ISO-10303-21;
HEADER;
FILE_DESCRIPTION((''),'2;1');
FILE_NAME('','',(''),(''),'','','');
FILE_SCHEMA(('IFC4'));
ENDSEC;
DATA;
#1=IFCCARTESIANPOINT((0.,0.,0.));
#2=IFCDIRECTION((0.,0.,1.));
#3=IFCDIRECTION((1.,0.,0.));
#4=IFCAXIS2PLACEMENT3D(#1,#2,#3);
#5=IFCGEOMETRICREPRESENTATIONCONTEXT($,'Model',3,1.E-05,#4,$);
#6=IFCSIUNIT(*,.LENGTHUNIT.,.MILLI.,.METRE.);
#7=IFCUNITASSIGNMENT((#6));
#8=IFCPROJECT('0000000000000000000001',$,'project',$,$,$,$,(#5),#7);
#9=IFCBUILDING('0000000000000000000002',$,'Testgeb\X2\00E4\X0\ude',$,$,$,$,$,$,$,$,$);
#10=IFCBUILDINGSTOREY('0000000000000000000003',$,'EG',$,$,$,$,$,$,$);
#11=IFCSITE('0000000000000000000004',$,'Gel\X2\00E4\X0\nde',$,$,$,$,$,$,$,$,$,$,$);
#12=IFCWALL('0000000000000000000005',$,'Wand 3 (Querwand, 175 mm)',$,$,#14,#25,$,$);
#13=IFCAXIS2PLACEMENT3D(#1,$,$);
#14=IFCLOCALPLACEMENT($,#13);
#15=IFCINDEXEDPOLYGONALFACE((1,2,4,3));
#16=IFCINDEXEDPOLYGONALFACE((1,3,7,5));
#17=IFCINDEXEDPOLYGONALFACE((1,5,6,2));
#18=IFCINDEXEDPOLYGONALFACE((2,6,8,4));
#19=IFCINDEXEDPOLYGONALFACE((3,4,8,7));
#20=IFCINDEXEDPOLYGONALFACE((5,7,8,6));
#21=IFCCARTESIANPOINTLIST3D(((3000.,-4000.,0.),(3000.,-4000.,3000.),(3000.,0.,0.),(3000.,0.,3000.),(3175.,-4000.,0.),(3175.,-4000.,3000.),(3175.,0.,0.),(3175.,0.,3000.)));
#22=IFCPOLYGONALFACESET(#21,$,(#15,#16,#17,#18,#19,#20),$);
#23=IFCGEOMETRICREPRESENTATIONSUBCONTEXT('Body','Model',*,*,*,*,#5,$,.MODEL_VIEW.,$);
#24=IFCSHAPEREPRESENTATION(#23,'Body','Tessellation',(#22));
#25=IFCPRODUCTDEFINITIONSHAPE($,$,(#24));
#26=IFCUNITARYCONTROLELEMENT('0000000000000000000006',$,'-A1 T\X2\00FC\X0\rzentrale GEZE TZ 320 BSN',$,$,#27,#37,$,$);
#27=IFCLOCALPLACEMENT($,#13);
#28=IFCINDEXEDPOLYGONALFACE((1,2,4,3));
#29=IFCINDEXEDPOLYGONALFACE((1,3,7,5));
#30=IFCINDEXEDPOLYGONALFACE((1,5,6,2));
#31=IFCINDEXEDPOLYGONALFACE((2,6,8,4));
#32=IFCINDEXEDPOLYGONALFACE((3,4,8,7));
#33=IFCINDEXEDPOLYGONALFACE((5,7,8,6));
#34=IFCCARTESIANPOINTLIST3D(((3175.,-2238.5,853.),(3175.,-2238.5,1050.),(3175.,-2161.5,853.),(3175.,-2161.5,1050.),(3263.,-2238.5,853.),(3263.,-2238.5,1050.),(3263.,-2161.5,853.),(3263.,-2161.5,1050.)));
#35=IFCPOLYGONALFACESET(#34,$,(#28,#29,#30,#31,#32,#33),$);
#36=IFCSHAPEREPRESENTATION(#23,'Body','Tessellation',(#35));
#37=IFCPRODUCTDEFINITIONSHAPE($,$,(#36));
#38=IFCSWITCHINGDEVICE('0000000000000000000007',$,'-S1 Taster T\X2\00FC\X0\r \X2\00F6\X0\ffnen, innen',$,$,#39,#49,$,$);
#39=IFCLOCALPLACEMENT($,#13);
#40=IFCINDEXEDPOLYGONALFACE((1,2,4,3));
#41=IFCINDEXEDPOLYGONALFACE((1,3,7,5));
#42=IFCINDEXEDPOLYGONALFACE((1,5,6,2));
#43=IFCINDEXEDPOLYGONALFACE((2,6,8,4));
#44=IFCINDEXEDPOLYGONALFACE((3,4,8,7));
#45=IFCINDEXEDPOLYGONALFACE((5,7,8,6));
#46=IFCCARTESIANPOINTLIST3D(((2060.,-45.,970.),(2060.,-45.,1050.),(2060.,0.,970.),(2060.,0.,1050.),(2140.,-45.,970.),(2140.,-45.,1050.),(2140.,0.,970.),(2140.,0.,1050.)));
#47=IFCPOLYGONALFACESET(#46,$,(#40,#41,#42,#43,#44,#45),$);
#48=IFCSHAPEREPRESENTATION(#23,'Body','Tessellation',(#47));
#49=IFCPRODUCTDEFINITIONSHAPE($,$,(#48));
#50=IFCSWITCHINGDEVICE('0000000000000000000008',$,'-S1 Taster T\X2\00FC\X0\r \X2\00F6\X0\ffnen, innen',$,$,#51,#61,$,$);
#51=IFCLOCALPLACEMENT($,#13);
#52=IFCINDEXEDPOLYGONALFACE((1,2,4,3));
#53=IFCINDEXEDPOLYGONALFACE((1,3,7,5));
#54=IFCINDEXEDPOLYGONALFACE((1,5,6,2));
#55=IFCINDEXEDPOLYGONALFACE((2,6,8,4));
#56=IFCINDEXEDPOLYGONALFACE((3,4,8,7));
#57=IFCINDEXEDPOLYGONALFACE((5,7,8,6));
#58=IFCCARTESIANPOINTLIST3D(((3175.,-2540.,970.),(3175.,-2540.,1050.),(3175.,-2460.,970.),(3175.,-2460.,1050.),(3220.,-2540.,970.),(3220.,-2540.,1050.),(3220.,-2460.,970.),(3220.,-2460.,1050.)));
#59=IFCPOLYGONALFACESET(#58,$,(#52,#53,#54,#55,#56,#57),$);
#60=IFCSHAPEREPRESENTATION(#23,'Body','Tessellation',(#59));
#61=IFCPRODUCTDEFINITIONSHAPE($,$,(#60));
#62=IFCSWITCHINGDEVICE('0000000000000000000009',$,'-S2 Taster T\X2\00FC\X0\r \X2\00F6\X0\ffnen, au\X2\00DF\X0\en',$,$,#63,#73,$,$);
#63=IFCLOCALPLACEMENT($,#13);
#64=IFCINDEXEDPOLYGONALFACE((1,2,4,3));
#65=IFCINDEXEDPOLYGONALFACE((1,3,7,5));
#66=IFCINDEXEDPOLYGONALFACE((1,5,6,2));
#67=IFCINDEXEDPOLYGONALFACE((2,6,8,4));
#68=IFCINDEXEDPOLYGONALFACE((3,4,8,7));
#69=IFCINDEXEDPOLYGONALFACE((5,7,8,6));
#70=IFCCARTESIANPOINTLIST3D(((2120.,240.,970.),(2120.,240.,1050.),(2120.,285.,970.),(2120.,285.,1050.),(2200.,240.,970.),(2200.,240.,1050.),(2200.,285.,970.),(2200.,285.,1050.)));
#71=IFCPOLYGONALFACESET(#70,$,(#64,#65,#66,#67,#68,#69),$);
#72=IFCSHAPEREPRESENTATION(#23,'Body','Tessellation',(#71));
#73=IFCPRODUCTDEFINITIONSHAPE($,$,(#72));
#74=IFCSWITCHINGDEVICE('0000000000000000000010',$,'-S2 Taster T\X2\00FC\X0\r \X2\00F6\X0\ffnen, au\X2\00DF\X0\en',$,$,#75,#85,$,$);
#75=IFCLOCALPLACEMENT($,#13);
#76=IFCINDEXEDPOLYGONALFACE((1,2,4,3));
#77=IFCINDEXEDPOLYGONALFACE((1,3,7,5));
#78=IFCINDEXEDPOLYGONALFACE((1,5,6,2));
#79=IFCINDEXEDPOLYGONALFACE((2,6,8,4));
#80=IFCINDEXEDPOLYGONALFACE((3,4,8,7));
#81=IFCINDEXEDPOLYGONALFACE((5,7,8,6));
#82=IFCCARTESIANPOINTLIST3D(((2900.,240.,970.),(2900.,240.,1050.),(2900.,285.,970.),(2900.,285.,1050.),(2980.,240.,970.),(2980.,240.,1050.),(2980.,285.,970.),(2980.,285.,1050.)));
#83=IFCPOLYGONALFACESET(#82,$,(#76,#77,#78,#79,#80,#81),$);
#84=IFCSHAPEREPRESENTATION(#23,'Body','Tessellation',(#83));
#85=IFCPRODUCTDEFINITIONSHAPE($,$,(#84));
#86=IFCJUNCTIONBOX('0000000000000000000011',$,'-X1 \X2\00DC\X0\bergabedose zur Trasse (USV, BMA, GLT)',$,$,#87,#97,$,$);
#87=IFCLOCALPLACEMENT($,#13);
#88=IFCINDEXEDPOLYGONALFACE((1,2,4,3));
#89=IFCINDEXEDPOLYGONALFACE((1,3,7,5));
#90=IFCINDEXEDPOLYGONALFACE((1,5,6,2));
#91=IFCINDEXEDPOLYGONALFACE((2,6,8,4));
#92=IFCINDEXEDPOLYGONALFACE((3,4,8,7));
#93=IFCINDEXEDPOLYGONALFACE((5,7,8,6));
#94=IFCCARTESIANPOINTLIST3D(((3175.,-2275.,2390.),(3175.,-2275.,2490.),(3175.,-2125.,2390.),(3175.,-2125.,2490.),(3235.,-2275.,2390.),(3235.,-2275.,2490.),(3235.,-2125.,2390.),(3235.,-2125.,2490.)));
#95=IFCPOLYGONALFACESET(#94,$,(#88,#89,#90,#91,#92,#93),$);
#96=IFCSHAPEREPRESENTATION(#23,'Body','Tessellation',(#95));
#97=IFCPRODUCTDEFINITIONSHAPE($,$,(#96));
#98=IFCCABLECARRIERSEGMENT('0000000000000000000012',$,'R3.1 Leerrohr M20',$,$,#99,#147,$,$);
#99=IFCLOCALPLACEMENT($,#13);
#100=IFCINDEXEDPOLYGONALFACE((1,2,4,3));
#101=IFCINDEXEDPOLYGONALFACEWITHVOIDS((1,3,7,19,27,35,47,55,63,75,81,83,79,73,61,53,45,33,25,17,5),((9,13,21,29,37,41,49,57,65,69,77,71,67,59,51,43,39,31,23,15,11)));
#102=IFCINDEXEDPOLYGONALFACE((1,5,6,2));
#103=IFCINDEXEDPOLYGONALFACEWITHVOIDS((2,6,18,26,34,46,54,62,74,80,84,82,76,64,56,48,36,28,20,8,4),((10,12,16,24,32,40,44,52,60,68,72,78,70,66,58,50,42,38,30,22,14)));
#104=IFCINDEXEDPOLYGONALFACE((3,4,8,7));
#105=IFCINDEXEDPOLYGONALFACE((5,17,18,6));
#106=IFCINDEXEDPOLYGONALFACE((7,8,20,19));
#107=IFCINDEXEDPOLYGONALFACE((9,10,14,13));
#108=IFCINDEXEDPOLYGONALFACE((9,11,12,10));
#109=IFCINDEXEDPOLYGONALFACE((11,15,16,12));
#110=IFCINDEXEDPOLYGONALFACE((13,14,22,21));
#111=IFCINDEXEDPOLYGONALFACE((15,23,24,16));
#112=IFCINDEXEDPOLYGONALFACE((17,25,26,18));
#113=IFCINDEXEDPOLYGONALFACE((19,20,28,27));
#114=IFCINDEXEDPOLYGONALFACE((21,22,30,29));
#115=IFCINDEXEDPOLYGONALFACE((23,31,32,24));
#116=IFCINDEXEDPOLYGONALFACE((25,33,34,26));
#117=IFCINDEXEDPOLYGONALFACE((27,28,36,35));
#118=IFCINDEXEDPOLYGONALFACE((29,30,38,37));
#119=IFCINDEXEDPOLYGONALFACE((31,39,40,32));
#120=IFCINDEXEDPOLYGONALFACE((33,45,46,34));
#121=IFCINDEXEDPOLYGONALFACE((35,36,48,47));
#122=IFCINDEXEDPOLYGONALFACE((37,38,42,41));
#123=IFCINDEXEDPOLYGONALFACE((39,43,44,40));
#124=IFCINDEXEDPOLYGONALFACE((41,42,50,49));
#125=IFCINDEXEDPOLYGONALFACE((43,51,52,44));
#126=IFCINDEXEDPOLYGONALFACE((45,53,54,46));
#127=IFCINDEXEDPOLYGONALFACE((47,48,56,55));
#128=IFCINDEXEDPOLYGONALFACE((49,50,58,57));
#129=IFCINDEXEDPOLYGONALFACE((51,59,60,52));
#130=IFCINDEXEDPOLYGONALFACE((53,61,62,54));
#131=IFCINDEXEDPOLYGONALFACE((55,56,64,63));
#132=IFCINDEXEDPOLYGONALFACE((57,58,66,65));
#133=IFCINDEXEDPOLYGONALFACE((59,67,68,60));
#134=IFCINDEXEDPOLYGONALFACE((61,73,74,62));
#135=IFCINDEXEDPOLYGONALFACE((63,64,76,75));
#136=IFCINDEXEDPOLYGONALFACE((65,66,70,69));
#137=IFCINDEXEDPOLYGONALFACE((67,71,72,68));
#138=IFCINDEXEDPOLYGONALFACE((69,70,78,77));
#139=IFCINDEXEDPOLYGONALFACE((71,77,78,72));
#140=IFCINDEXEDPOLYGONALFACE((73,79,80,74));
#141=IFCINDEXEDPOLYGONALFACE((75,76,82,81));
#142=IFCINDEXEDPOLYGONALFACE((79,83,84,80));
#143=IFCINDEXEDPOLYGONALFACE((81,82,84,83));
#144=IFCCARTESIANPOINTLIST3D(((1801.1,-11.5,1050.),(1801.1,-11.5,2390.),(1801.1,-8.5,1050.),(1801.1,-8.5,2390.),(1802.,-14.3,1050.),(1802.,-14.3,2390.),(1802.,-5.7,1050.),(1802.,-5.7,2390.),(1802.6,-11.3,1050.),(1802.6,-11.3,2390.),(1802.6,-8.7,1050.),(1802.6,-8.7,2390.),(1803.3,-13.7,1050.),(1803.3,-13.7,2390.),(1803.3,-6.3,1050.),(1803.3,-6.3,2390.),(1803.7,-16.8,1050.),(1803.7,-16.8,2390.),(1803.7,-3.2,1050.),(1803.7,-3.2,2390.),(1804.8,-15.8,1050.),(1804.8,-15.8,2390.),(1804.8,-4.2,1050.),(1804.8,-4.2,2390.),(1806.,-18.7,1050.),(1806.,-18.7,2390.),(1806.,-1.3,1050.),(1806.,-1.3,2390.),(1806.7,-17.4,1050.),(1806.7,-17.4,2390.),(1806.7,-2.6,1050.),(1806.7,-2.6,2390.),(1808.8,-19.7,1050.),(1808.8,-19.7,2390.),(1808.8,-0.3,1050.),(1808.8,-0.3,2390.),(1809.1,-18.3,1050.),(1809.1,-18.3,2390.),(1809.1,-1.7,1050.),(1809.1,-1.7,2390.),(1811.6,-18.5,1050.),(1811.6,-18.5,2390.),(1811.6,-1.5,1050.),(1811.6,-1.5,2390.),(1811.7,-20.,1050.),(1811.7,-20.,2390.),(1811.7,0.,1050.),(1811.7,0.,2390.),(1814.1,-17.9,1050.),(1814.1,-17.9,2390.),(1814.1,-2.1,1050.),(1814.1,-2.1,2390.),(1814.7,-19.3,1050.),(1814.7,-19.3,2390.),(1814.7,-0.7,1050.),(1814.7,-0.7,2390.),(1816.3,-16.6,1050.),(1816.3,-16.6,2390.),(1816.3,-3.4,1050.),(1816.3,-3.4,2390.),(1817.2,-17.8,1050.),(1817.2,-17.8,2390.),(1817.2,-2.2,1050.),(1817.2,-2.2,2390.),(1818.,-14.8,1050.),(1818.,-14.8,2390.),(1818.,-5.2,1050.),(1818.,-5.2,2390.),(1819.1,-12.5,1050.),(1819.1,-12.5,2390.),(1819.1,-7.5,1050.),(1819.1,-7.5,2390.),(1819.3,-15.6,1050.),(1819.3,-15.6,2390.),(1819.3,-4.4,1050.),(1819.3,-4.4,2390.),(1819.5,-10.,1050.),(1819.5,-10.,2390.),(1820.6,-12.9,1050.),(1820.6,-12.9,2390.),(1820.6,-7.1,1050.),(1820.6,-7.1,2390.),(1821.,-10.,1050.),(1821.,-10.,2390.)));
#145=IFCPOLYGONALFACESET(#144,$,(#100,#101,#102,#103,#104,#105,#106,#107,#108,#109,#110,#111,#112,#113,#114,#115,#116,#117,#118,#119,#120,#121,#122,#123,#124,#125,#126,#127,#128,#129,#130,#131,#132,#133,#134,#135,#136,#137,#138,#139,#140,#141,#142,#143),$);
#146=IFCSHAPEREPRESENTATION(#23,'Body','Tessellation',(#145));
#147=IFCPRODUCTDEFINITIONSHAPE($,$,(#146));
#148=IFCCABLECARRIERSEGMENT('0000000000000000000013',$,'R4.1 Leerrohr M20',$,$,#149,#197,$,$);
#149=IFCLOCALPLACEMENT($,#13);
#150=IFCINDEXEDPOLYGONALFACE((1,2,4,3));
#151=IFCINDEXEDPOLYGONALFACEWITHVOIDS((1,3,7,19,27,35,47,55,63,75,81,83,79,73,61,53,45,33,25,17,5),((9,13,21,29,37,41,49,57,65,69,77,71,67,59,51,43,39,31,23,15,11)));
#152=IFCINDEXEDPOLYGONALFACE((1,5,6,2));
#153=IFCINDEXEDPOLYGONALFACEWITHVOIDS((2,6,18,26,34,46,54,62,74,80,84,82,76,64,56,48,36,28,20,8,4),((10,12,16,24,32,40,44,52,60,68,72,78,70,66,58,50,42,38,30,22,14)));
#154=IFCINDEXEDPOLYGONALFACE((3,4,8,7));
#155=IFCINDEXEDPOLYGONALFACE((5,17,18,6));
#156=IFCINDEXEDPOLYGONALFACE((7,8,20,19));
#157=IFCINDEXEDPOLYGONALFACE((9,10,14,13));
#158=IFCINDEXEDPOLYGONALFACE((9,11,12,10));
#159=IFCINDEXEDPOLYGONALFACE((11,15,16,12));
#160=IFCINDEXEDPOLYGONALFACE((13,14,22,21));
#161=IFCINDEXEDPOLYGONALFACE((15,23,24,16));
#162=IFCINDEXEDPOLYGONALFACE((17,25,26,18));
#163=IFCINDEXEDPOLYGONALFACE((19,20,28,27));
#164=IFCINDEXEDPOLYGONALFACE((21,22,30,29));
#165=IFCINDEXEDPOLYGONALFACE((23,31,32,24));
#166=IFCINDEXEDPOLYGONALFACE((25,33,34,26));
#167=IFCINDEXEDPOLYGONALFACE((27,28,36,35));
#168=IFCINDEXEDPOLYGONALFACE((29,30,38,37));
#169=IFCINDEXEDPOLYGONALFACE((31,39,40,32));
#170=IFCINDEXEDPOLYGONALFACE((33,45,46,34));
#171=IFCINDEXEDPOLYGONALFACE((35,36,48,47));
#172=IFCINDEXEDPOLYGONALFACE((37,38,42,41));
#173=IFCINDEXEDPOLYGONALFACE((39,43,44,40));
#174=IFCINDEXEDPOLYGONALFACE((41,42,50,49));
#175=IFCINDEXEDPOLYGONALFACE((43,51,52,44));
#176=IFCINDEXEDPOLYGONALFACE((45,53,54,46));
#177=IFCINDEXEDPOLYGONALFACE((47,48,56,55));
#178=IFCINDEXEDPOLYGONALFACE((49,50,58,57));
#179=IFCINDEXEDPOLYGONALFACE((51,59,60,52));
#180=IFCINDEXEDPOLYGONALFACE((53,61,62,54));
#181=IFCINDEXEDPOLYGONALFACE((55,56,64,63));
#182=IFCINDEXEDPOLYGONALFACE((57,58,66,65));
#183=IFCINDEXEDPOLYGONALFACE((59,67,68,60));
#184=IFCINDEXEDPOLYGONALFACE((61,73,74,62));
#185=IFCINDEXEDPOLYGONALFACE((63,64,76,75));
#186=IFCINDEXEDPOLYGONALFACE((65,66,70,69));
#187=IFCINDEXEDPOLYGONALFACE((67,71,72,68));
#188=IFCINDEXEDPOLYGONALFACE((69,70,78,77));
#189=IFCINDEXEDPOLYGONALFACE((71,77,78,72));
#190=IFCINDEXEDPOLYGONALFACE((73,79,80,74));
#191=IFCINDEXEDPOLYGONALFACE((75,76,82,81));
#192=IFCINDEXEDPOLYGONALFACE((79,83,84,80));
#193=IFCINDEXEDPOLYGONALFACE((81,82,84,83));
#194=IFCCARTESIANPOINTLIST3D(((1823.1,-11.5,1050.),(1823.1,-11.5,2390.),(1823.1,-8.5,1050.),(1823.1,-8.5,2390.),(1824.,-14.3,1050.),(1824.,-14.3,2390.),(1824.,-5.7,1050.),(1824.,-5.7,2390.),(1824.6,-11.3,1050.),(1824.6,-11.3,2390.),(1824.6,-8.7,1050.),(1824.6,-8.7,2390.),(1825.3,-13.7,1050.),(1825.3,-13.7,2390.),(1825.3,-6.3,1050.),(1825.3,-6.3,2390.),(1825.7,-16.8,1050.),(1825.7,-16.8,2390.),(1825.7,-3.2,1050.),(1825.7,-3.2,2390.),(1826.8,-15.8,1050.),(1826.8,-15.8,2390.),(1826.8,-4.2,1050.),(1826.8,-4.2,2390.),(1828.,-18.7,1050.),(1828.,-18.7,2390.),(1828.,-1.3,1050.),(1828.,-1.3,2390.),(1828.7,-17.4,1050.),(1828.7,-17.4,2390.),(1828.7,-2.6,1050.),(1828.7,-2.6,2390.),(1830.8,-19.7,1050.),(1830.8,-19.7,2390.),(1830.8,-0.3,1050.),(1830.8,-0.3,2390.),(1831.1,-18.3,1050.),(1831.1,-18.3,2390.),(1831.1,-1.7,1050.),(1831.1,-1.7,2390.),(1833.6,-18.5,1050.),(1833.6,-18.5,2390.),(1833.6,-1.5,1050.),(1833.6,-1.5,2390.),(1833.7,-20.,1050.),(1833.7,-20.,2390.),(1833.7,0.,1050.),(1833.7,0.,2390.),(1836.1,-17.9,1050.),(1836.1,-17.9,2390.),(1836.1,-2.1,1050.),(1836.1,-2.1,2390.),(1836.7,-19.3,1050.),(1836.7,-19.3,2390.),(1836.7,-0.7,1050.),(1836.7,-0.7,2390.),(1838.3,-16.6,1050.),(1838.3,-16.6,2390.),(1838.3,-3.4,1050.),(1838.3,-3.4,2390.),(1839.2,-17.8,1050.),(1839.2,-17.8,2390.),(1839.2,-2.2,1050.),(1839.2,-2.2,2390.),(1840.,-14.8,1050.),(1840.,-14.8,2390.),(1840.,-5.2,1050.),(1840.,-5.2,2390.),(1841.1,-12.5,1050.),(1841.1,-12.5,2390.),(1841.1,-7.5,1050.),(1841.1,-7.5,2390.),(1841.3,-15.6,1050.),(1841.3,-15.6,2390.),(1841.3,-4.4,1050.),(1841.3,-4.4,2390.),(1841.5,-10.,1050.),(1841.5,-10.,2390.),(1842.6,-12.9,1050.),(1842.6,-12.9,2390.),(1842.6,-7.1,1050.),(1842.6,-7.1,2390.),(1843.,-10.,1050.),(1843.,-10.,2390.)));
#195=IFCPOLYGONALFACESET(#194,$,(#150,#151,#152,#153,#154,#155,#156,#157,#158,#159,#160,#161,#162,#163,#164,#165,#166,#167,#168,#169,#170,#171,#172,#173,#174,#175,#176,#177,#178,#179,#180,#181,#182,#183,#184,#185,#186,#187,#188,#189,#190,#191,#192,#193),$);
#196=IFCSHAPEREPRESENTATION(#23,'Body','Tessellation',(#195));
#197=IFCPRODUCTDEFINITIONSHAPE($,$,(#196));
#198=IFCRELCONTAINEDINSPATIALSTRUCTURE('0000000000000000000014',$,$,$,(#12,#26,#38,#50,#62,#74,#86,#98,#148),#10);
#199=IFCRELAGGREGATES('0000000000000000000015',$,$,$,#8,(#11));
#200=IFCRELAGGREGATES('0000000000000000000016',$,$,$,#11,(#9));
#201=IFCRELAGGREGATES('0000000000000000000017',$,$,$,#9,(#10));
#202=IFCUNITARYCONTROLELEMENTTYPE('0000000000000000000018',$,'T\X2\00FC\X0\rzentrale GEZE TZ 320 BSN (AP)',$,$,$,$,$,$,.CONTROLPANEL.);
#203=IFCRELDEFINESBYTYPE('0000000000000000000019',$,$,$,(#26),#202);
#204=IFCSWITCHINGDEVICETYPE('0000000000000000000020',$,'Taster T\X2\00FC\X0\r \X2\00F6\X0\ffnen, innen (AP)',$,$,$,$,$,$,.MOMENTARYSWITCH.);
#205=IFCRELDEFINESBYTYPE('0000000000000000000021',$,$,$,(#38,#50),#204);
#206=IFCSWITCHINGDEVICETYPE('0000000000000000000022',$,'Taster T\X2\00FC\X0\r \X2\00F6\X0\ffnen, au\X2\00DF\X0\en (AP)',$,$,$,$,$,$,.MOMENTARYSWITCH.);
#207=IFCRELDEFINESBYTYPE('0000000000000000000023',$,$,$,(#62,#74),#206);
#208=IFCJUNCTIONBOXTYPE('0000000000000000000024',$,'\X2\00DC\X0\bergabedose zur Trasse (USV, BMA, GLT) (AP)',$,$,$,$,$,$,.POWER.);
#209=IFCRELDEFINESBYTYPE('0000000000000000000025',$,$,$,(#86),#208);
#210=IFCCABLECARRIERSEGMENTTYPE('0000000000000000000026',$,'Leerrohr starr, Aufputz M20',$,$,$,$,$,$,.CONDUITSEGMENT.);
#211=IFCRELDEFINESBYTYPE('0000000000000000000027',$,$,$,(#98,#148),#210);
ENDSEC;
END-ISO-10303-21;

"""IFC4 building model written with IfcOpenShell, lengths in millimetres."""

from ifc_helpers import new_model, si_unit, frame, frame_2d, origin_with_axes, place, context, subcontext, project, spatial, rectangle, hollow_circle, extrude, type_object, element, save


model = new_model("IFC4")

# Units and contexts
model_context = context("Model", 3, precision=1e-05, world=origin_with_axes())
body_context = subcontext(model_context, "Body", "Model", "MODEL_VIEW")
ifc_project = project(units=[si_unit("LENGTHUNIT", "METRE", prefix="MILLI")], contexts=[model_context])

# Site, building, storey
site = spatial("IfcSite", under=ifc_project, Name="Gelände")
building = spatial("IfcBuilding", under=site, Name="Testgebäude")
storey = spatial("IfcBuildingStorey", under=building, Name="EG")

# Wall
wall_placement = place(None, frame((3000.0, 0.0, 0.0), z_axis=(0.0, 0.0, 1.0), x_axis=(0.0, -1.0, 0.0)))
element("IfcWall", 1, at=wall_placement, inside=storey, Name="Wand 3 (Querwand, 175 mm)", context=body_context, shape_type="SweptSolid", body=[
    extrude(rectangle(XDim=4000.0, YDim=175.0, at=frame_2d((2000.0, 87.5))), None, (0.0, 0.0, 1.0), 3000.0),
])

# Unitary control element
unitary_control_element_type = type_object("IfcUnitaryControlElementType", Name="Türzentrale GEZE TZ 320 BSN (AP)", PredefinedType="CONTROLPANEL")
unitary_control_element_placement = place(None, frame((3175.0, -2238.5, 853.0), z_axis=(0.0, 0.0, 1.0), x_axis=(1.0, 0.0, 0.0)))
element("IfcUnitaryControlElement", 2, at=unitary_control_element_placement, inside=storey, type_object=unitary_control_element_type, Name="-A1 Türzentrale GEZE TZ 320 BSN", context=body_context, shape_type="SweptSolid", body=[
    extrude(rectangle(XDim=88.0, YDim=77.0, at=frame_2d((44.0, 38.5))), None, (0.0, 0.0, 1.0), 197.0),
])

# Switching devices
switching_device_type_1 = type_object("IfcSwitchingDeviceType", Name="Taster Tür öffnen, innen (AP)", PredefinedType="MOMENTARYSWITCH")
switching_device_1_placement = place(None, frame((2060.0, -45.0, 970.0), z_axis=(0.0, 0.0, 1.0), x_axis=(1.0, 0.0, 0.0)))
element("IfcSwitchingDevice", 3, at=switching_device_1_placement, inside=storey, type_object=switching_device_type_1, Name="-S1 Taster Tür öffnen, innen", context=body_context, shape_type="SweptSolid", body=[
    extrude(rectangle(XDim=80.0, YDim=45.0, at=frame_2d((40.0, 22.5))), None, (0.0, 0.0, 1.0), 80.0),
])
switching_device_2_placement = place(None, frame((3175.0, -2540.0, 970.0), z_axis=(0.0, 0.0, 1.0), x_axis=(1.0, 0.0, 0.0)))
element("IfcSwitchingDevice", 4, at=switching_device_2_placement, inside=storey, type_object=switching_device_type_1, Name="-S1 Taster Tür öffnen, innen", context=body_context, shape_type="SweptSolid", body=[
    extrude(rectangle(XDim=45.0, YDim=80.0, at=frame_2d((22.5, 40.0))), None, (0.0, 0.0, 1.0), 80.0),
])
switching_device_type_2 = type_object("IfcSwitchingDeviceType", Name="Taster Tür öffnen, außen (AP)", PredefinedType="MOMENTARYSWITCH")
for number, where, z_axis, x_axis, name in (
    (5, (2120.0, 240.0, 970.0), (0.0, 0.0, 1.0), (1.0, 0.0, 0.0), "-S2 Taster Tür öffnen, außen"),
    (6, (2900.0, 240.0, 970.0), (0.0, 0.0, 1.0), (1.0, 0.0, 0.0), "-S2 Taster Tür öffnen, außen"),
):
    element("IfcSwitchingDevice", number, at=place(None, frame(where, z_axis=z_axis, x_axis=x_axis)), inside=storey, type_object=switching_device_type_2, Name=name, context=body_context, shape_type="SweptSolid", body=[
        extrude(rectangle(XDim=80.0, YDim=45.0, at=frame_2d((40.0, 22.5))), None, (0.0, 0.0, 1.0), 80.0),
    ])

# Junction box
junction_box_type = type_object("IfcJunctionBoxType", Name="Übergabedose zur Trasse (USV, BMA, GLT) (AP)", PredefinedType="POWER")
junction_box_placement = place(None, frame((3175.0, -2275.0, 2390.0), z_axis=(0.0, 0.0, 1.0), x_axis=(1.0, 0.0, 0.0)))
element("IfcJunctionBox", 7, at=junction_box_placement, inside=storey, type_object=junction_box_type, Name="-X1 Übergabedose zur Trasse (USV, BMA, GLT)", context=body_context, shape_type="SweptSolid", body=[
    extrude(rectangle(XDim=60.0, YDim=150.0, at=frame_2d((30.0, 75.0))), None, (0.0, 0.0, 1.0), 100.0),
])

# Cable carrier segments
cable_carrier_segment_type_1 = type_object("IfcCableCarrierSegmentType", Name="Leerrohr starr, Aufputz M20", PredefinedType="CONDUITSEGMENT")
for number, where, z_axis, x_axis, name in (
    (8, (1811.0, -10.0, 1050.0), (0.0, 0.0, 1.0), (1.0, 0.0, 0.0), "R3.1 Leerrohr M20"),
    (9, (1833.0, -10.0, 1050.0), (0.0, 0.0, 1.0), (1.0, 0.0, 0.0), "R4.1 Leerrohr M20"),
):
    element("IfcCableCarrierSegment", number, at=place(None, frame(where, z_axis=z_axis, x_axis=x_axis)), inside=storey, type_object=cable_carrier_segment_type_1, Name=name, context=body_context, shape_type="SweptSolid", body=[
        extrude(hollow_circle(Radius=10.0, WallThickness=1.5), None, (0.0, 0.0, 1.0), 1340.0),
    ])

save(model, "model.ifc")
